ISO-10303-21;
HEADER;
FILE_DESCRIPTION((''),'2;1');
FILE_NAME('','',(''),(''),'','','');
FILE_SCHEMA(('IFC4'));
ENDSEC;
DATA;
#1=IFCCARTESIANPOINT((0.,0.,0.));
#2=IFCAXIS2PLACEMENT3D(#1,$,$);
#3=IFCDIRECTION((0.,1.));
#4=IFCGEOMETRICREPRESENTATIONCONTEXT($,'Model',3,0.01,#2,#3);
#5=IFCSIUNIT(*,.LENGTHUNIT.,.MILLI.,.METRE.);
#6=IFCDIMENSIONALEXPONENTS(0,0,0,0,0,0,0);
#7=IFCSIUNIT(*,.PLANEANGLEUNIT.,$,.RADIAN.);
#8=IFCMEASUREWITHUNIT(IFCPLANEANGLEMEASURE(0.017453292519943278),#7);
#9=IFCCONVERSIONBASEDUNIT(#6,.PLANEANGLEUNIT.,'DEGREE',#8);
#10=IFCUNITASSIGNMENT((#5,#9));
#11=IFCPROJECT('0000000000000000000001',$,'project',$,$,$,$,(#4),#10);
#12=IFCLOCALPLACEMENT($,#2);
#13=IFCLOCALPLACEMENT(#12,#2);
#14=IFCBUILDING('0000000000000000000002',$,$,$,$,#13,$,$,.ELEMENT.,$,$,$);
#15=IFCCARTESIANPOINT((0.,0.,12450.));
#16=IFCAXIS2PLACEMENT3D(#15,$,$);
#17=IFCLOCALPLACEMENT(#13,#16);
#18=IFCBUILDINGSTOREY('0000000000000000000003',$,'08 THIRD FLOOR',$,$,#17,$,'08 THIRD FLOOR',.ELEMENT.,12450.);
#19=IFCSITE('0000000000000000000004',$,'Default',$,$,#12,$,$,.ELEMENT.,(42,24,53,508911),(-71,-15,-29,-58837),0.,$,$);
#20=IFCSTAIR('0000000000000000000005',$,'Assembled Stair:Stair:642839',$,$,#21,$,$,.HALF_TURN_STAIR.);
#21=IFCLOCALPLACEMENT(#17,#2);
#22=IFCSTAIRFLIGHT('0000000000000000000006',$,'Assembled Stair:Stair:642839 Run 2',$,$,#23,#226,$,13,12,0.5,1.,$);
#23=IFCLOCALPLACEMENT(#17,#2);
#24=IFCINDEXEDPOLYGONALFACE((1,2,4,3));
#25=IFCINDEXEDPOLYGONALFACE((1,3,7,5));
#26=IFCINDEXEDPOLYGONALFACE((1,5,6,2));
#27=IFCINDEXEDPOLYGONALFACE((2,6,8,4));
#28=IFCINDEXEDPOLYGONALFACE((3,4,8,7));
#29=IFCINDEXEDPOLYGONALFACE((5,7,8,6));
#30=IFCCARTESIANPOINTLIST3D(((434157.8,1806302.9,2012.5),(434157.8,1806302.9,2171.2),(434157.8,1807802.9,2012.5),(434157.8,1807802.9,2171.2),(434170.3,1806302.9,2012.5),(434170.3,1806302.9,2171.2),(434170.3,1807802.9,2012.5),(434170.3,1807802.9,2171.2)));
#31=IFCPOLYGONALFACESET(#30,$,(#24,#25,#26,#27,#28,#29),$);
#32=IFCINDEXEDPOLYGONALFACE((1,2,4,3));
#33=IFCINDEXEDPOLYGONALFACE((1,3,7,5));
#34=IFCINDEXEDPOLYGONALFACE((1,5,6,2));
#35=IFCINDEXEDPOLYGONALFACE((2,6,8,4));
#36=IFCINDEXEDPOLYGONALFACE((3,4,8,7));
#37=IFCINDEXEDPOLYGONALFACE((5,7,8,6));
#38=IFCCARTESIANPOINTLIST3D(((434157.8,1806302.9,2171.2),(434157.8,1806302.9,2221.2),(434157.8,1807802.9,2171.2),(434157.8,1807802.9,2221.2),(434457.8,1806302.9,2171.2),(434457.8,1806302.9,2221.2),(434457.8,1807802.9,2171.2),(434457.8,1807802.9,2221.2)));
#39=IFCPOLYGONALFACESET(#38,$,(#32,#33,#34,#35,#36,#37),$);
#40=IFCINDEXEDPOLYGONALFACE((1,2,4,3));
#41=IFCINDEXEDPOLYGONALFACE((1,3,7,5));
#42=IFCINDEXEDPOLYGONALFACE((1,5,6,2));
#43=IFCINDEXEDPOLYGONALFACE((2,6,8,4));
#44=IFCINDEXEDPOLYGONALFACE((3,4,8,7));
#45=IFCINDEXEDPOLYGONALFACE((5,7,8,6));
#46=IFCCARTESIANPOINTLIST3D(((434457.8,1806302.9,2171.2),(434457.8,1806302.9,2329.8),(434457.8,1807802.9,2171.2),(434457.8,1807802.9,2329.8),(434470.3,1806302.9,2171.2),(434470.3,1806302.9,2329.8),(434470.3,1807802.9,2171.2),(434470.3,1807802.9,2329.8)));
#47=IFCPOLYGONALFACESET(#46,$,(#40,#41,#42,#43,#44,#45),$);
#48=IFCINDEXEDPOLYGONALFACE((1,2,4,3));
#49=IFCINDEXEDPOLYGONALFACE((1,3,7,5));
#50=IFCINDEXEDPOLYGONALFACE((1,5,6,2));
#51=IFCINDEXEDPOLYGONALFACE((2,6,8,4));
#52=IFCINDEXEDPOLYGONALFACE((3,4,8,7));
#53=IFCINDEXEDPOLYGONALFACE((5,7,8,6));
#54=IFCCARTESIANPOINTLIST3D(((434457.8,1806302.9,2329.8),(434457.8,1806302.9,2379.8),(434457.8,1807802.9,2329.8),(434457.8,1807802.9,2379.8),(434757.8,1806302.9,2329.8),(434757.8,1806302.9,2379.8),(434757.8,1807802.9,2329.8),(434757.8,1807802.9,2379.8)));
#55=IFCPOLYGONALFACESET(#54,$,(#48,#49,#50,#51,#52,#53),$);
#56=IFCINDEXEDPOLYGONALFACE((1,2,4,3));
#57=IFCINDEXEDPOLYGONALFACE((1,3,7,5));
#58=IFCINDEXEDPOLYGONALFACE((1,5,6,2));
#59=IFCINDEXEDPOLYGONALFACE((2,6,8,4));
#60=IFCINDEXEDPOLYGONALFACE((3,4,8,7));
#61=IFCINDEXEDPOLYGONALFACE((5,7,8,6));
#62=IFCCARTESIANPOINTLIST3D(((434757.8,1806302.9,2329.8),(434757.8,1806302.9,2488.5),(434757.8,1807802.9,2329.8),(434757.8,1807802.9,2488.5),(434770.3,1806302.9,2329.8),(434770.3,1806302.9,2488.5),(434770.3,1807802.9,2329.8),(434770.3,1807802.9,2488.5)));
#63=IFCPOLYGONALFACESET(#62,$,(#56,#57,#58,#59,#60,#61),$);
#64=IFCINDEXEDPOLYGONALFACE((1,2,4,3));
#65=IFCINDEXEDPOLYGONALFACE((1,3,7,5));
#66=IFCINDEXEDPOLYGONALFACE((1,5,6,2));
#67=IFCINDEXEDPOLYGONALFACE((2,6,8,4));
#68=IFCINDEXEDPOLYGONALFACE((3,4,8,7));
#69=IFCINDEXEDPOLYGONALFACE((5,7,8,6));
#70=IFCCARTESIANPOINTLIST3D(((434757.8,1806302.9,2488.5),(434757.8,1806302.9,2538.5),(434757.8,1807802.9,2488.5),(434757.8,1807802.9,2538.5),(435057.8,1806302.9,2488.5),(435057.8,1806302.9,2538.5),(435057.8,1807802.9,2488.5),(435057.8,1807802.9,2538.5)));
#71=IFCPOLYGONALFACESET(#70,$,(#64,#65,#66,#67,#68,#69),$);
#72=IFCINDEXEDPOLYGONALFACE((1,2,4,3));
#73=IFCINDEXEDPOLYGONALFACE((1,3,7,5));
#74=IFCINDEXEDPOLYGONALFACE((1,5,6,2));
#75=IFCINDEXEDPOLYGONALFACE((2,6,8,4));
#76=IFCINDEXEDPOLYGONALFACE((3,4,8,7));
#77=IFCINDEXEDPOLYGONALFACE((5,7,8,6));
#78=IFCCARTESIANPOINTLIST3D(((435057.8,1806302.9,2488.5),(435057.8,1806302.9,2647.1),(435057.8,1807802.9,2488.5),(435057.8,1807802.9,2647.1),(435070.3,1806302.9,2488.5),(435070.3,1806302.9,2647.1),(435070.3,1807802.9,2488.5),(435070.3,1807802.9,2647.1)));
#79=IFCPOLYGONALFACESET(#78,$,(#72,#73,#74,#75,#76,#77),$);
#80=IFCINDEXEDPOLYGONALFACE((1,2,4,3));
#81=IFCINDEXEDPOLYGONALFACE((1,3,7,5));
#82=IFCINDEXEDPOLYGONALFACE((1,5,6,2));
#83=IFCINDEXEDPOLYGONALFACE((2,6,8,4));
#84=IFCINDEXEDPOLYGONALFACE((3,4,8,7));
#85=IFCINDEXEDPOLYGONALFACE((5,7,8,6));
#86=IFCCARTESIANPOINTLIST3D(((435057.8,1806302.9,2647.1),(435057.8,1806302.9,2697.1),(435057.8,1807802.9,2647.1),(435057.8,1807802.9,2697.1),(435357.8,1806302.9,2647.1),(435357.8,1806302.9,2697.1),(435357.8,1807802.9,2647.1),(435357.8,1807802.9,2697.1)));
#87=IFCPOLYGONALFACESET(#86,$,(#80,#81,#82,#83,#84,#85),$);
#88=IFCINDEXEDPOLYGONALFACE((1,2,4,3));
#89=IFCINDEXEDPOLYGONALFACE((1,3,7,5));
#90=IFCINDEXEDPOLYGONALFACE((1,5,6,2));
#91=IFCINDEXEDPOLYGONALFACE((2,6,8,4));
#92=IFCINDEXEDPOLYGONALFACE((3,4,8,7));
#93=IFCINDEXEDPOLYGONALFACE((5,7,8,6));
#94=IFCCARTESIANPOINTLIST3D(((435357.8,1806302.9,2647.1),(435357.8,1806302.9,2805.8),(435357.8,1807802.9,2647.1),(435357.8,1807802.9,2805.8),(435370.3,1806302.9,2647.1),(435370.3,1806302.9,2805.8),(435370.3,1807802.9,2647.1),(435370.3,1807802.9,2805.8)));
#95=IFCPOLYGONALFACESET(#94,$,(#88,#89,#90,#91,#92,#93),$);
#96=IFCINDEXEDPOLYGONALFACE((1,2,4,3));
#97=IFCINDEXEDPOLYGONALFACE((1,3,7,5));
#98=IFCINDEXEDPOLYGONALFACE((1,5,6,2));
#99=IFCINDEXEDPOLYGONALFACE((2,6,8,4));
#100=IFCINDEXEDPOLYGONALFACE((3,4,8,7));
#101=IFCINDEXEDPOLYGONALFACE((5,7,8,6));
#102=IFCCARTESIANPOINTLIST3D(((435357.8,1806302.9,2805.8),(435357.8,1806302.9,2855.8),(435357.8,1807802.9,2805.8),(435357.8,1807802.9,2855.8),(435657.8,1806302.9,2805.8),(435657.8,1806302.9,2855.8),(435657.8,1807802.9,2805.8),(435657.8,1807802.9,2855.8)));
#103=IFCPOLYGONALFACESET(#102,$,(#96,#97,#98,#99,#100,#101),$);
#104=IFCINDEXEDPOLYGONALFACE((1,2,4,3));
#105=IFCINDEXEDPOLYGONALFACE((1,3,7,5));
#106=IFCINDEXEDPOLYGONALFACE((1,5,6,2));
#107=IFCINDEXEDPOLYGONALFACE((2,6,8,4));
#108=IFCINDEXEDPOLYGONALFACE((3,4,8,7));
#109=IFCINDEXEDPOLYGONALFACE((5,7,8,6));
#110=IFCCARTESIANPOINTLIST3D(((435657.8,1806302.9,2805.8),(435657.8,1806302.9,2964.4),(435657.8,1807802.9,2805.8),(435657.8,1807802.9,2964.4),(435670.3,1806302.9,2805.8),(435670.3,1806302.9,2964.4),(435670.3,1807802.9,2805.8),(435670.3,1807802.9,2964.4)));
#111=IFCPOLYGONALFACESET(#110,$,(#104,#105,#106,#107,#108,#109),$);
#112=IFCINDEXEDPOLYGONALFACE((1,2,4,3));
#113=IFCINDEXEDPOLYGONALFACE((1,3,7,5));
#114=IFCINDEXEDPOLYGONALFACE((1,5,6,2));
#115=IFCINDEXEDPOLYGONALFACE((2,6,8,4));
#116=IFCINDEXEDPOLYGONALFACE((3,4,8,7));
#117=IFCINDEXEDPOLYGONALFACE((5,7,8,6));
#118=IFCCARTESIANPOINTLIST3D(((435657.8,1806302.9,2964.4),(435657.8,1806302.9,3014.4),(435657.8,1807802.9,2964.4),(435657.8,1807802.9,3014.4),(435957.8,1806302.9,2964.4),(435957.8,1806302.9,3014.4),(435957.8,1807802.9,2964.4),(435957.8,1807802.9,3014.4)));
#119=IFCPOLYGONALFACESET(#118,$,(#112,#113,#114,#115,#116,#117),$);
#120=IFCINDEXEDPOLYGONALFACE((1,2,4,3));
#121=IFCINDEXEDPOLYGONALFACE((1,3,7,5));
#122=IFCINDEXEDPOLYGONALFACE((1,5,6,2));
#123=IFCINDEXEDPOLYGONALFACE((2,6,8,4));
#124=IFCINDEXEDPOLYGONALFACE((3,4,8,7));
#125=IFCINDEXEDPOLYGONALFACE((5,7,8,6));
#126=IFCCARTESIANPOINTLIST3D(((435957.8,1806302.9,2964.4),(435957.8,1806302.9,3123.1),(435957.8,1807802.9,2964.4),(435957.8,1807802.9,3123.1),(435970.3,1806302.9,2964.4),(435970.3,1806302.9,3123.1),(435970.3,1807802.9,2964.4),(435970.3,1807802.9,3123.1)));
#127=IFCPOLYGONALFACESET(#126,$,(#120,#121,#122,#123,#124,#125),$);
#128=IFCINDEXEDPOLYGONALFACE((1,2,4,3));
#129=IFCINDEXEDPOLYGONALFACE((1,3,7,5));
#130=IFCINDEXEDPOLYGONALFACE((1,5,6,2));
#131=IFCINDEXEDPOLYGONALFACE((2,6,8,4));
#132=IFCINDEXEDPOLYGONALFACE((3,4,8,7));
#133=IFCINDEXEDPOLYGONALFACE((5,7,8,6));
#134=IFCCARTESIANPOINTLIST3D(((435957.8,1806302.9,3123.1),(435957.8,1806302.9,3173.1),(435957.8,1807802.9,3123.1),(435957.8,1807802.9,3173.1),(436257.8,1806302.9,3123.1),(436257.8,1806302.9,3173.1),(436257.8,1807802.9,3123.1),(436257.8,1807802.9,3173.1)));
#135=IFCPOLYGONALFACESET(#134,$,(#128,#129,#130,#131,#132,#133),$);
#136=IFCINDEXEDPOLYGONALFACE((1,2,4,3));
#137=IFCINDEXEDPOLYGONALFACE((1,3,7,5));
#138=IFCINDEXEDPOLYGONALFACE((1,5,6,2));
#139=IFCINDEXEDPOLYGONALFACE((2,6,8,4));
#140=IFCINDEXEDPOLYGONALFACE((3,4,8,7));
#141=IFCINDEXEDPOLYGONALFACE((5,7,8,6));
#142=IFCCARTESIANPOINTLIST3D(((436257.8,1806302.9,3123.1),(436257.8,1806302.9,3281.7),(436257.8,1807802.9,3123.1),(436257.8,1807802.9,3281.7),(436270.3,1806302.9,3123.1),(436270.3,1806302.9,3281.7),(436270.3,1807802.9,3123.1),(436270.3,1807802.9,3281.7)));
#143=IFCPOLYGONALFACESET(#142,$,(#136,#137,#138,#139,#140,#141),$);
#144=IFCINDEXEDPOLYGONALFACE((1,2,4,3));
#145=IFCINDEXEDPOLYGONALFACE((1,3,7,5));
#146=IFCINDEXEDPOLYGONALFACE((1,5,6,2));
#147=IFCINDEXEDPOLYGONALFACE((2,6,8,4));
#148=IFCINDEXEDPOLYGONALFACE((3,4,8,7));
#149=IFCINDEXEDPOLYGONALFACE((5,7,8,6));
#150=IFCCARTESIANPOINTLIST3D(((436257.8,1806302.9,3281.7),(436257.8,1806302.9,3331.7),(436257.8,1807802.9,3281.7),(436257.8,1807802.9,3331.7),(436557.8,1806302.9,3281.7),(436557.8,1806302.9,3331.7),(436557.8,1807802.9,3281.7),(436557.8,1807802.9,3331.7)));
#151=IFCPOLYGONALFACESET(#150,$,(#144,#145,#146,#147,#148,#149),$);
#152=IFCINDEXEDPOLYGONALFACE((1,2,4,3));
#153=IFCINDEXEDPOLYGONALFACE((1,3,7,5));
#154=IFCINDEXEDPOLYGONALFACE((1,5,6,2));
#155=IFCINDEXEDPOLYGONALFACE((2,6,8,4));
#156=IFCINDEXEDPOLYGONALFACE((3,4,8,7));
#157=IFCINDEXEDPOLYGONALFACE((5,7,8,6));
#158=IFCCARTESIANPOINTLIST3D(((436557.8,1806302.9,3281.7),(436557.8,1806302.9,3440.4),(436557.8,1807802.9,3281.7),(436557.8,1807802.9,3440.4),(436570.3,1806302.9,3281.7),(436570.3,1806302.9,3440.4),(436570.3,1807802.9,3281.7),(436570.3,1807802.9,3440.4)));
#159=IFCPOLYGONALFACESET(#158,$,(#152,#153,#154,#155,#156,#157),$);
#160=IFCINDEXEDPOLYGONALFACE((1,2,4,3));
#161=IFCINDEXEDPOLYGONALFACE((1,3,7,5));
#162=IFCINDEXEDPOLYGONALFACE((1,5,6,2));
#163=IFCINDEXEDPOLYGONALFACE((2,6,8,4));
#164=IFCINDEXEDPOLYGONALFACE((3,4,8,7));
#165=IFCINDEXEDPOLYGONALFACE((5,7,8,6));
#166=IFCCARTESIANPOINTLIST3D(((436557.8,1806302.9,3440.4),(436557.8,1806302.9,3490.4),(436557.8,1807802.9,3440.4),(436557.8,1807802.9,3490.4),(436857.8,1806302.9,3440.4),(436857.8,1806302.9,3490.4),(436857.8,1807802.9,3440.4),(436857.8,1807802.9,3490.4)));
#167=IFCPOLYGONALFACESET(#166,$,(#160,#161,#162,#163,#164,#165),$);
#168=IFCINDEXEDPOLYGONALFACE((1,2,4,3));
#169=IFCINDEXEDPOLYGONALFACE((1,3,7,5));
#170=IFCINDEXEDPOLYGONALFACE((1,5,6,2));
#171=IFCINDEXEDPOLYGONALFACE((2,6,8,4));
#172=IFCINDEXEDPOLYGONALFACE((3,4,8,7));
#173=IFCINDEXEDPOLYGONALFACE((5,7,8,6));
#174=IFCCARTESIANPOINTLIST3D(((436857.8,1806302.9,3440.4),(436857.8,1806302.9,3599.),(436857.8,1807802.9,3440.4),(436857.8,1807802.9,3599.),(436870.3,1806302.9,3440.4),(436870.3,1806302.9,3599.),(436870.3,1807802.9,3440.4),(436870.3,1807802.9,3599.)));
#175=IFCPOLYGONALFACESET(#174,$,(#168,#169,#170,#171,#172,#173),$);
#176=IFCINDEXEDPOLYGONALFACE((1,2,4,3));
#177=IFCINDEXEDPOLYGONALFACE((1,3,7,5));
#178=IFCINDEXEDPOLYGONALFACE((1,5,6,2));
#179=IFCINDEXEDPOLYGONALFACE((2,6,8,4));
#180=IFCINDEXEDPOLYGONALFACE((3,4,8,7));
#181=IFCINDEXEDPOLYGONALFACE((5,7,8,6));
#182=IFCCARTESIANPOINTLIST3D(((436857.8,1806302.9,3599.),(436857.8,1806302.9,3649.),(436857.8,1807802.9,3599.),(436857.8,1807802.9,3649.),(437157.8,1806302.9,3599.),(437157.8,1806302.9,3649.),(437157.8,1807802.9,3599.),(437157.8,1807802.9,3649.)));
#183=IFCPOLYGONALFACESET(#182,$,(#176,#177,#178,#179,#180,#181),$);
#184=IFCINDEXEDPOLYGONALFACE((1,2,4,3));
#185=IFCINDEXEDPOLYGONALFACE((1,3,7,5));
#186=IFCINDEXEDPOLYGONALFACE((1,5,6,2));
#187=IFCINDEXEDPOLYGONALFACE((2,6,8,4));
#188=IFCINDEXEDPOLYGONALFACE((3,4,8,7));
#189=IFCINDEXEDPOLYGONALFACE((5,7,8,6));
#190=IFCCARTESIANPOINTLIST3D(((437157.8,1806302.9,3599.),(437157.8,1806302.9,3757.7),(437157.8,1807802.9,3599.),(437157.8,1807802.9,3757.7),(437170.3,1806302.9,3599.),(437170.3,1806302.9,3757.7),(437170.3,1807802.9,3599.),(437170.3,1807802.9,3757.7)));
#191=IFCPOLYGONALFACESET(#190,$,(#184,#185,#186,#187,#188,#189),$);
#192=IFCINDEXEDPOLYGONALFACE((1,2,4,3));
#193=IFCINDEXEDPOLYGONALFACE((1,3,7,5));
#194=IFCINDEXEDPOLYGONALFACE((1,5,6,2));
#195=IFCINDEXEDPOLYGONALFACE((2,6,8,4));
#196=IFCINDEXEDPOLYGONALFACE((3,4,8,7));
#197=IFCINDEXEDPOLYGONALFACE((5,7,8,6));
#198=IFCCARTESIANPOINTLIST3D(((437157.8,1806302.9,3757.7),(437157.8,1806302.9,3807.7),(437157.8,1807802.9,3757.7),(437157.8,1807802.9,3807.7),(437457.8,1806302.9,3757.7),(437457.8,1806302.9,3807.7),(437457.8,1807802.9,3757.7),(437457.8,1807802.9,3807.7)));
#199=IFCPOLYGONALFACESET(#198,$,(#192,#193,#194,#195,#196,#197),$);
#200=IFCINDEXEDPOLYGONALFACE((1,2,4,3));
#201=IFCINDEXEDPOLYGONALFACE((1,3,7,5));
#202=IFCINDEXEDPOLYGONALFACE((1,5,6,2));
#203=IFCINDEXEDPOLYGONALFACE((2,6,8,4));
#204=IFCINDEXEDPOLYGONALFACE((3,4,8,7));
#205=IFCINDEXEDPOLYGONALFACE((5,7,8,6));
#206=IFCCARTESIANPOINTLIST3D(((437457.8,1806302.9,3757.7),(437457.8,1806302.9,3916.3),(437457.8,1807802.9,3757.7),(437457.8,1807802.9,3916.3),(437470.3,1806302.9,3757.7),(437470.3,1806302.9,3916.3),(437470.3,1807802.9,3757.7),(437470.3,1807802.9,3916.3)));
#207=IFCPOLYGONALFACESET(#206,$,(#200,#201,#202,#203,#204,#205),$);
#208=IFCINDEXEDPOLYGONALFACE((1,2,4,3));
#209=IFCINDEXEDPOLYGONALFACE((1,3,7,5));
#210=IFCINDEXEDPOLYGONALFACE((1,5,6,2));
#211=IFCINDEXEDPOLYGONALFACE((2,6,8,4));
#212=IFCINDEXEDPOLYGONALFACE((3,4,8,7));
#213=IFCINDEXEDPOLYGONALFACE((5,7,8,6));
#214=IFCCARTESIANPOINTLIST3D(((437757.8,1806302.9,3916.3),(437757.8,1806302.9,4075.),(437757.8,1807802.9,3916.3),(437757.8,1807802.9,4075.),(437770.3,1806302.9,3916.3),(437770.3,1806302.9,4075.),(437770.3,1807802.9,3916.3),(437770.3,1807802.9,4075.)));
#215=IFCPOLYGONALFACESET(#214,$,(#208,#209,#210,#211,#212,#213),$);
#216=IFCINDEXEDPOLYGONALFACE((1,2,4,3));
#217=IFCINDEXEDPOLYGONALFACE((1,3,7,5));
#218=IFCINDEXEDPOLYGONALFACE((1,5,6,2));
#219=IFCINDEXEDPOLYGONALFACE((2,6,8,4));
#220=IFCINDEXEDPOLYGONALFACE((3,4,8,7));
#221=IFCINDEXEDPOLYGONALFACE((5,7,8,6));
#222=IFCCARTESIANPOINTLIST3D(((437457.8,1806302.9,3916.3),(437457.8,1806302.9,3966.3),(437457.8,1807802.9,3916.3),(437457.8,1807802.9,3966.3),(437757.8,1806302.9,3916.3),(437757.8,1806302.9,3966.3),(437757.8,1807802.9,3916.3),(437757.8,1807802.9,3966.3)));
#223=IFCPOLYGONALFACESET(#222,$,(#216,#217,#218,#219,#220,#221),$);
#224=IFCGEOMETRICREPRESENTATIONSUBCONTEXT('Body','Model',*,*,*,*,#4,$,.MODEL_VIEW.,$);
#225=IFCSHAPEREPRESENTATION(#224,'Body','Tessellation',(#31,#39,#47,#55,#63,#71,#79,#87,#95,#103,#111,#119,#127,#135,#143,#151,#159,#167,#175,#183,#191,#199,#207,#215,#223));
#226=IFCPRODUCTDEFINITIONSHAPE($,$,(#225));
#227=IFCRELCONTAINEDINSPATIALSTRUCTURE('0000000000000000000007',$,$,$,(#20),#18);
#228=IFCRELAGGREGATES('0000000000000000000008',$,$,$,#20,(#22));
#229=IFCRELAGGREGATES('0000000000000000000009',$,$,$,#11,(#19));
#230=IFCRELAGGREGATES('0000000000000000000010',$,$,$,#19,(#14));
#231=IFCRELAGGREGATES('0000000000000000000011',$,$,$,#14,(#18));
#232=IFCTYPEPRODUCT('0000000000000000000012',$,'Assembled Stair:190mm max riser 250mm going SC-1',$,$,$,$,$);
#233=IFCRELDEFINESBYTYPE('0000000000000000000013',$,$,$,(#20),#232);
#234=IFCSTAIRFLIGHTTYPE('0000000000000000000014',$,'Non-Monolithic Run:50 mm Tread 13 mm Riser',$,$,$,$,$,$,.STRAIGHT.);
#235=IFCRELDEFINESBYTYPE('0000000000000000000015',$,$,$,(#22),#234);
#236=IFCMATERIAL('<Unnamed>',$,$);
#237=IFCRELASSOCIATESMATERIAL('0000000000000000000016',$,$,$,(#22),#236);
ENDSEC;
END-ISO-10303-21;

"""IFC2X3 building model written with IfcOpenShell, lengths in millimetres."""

from ifc_helpers import new_model, entity, si_unit, converted_unit, direction, frame, origin, origin_2d_with_axis, place, context, subcontext, project, spatial, rectangle, extrude, material, type_object, element, aggregate, save


model = new_model("IFC2X3")

# Units and contexts
model_context = context("Model", 3, precision=0.01, world=origin(), true_north=direction((0.0, 1.0)))
body_context = subcontext(model_context, "Body", "Model", "MODEL_VIEW")
ifc_project = project(units=[si_unit("LENGTHUNIT", "METRE", prefix="MILLI"), converted_unit("PLANEANGLEUNIT", "DEGREE", entity("IfcPlaneAngleMeasure", 0.017453292519943278), si_unit("PLANEANGLEUNIT", "RADIAN"), dimensions=[0, 0, 0, 0, 0, 0, 0])], contexts=[model_context])

# Site, building, storey
site_placement = place(None, origin())
site = spatial("IfcSite", under=ifc_project, at=site_placement, Name="Default", CompositionType="ELEMENT", RefLatitude=(42, 24, 53, 508911), RefLongitude=(-71, -15, -29, -58837), RefElevation=0.0)
building_placement = place(site_placement, origin())
building = spatial("IfcBuilding", under=site, at=building_placement, CompositionType="ELEMENT")
storey_placement = place(building_placement, frame((0.0, 0.0, 12450.0)))
storey = spatial("IfcBuildingStorey", under=building, at=storey_placement, Name="08 THIRD FLOOR", LongName="08 THIRD FLOOR", CompositionType="ELEMENT", Elevation=12450.0)

# Stair
type_product_1 = type_object("IfcTypeProduct", Name="Assembled Stair:190mm max riser 250mm going SC-1")
stair_1_placement = place(storey_placement, origin())
stair_1 = element("IfcStair", 1, at=stair_1_placement, inside=storey, type_object=type_product_1, Name="Assembled Stair:Stair:642839", ShapeType="HALF_TURN_STAIR")
ifc_material_1 = material(Name="<Unnamed>")

# Stair flight
stair_flight_type = type_object("IfcStairFlightType", Name="Non-Monolithic Run:50 mm Tread 13 mm Riser", PredefinedType="STRAIGHT")
stair_flight_1_placement = place(stair_1_placement, origin())
stair_flight_1 = element("IfcStairFlight", 2, at=stair_flight_1_placement, type_object=stair_flight_type, material=ifc_material_1, Name="Assembled Stair:Stair:642839 Run 2", NumberOfRiser=13, NumberOfTreads=12, RiserHeight=0.5, TreadLength=1.0, context=body_context, shape_type="SweptSolid", body=[
    extrude(rectangle(XDim=1500.0, YDim=12.5, at=origin_2d_with_axis()), frame((434164.0, 1807052.9, 2012.5), z_axis=(0.0, 0.0, 1.0), x_axis=(0.0, 1.0, 0.0)), (0.0, 0.0, 1.0), 158.7),
    extrude(rectangle(XDim=300.0, YDim=1500.0, at=origin_2d_with_axis()), frame((434307.8, 1807052.9, 2171.2), z_axis=(0.0, 0.0, 1.0), x_axis=(-1.0, 0.0, 0.0)), (0.0, 0.0, 1.0), 50.0),
    extrude(rectangle(XDim=1500.0, YDim=12.5, at=origin_2d_with_axis()), frame((434464.0, 1807052.9, 2171.2), z_axis=(0.0, 0.0, 1.0), x_axis=(0.0, 1.0, 0.0)), (0.0, 0.0, 1.0), 158.7),
    extrude(rectangle(XDim=300.0, YDim=1500.0, at=origin_2d_with_axis()), frame((434607.8, 1807052.9, 2329.8), z_axis=(0.0, 0.0, 1.0), x_axis=(-1.0, 0.0, 0.0)), (0.0, 0.0, 1.0), 50.0),
    extrude(rectangle(XDim=1500.0, YDim=12.5, at=origin_2d_with_axis()), frame((434764.0, 1807052.9, 2329.8), z_axis=(0.0, 0.0, 1.0), x_axis=(0.0, 1.0, 0.0)), (0.0, 0.0, 1.0), 158.7),
    extrude(rectangle(XDim=300.0, YDim=1500.0, at=origin_2d_with_axis()), frame((434907.8, 1807052.9, 2488.5), z_axis=(0.0, 0.0, 1.0), x_axis=(-1.0, 0.0, 0.0)), (0.0, 0.0, 1.0), 50.0),
    extrude(rectangle(XDim=1500.0, YDim=12.5, at=origin_2d_with_axis()), frame((435064.0, 1807052.9, 2488.5), z_axis=(0.0, 0.0, 1.0), x_axis=(0.0, 1.0, 0.0)), (0.0, 0.0, 1.0), 158.7),
    extrude(rectangle(XDim=300.0, YDim=1500.0, at=origin_2d_with_axis()), frame((435207.8, 1807052.9, 2647.1), z_axis=(0.0, 0.0, 1.0), x_axis=(-1.0, 0.0, 0.0)), (0.0, 0.0, 1.0), 50.0),
    extrude(rectangle(XDim=1500.0, YDim=12.5, at=origin_2d_with_axis()), frame((435364.0, 1807052.9, 2647.1), z_axis=(0.0, 0.0, 1.0), x_axis=(0.0, 1.0, 0.0)), (0.0, 0.0, 1.0), 158.7),
    extrude(rectangle(XDim=300.0, YDim=1500.0, at=origin_2d_with_axis()), frame((435507.8, 1807052.9, 2805.8), z_axis=(0.0, 0.0, 1.0), x_axis=(-1.0, 0.0, 0.0)), (0.0, 0.0, 1.0), 50.0),
    extrude(rectangle(XDim=1500.0, YDim=12.5, at=origin_2d_with_axis()), frame((435664.0, 1807052.9, 2805.8), z_axis=(0.0, 0.0, 1.0), x_axis=(0.0, 1.0, 0.0)), (0.0, 0.0, 1.0), 158.7),
    extrude(rectangle(XDim=300.0, YDim=1500.0, at=origin_2d_with_axis()), frame((435807.8, 1807052.9, 2964.4), z_axis=(0.0, 0.0, 1.0), x_axis=(-1.0, 0.0, 0.0)), (0.0, 0.0, 1.0), 50.0),
    extrude(rectangle(XDim=1500.0, YDim=12.5, at=origin_2d_with_axis()), frame((435964.0, 1807052.9, 2964.4), z_axis=(0.0, 0.0, 1.0), x_axis=(0.0, 1.0, 0.0)), (0.0, 0.0, 1.0), 158.7),
    extrude(rectangle(XDim=300.0, YDim=1500.0, at=origin_2d_with_axis()), frame((436107.8, 1807052.9, 3123.1), z_axis=(0.0, 0.0, 1.0), x_axis=(-1.0, 0.0, 0.0)), (0.0, 0.0, 1.0), 50.0),
    extrude(rectangle(XDim=1500.0, YDim=12.5, at=origin_2d_with_axis()), frame((436264.0, 1807052.9, 3123.1), z_axis=(0.0, 0.0, 1.0), x_axis=(0.0, 1.0, 0.0)), (0.0, 0.0, 1.0), 158.7),
    extrude(rectangle(XDim=300.0, YDim=1500.0, at=origin_2d_with_axis()), frame((436407.8, 1807052.9, 3281.7), z_axis=(0.0, 0.0, 1.0), x_axis=(-1.0, 0.0, 0.0)), (0.0, 0.0, 1.0), 50.0),
    extrude(rectangle(XDim=1500.0, YDim=12.5, at=origin_2d_with_axis()), frame((436564.0, 1807052.9, 3281.7), z_axis=(0.0, 0.0, 1.0), x_axis=(0.0, 1.0, 0.0)), (0.0, 0.0, 1.0), 158.7),
    extrude(rectangle(XDim=300.0, YDim=1500.0, at=origin_2d_with_axis()), frame((436707.8, 1807052.9, 3440.4), z_axis=(0.0, 0.0, 1.0), x_axis=(-1.0, 0.0, 0.0)), (0.0, 0.0, 1.0), 50.0),
    extrude(rectangle(XDim=1500.0, YDim=12.5, at=origin_2d_with_axis()), frame((436864.0, 1807052.9, 3440.4), z_axis=(0.0, 0.0, 1.0), x_axis=(0.0, 1.0, 0.0)), (0.0, 0.0, 1.0), 158.7),
    extrude(rectangle(XDim=300.0, YDim=1500.0, at=origin_2d_with_axis()), frame((437007.8, 1807052.9, 3599.0), z_axis=(0.0, 0.0, 1.0), x_axis=(-1.0, 0.0, 0.0)), (0.0, 0.0, 1.0), 50.0),
    extrude(rectangle(XDim=1500.0, YDim=12.5, at=origin_2d_with_axis()), frame((437164.0, 1807052.9, 3599.0), z_axis=(0.0, 0.0, 1.0), x_axis=(0.0, 1.0, 0.0)), (0.0, 0.0, 1.0), 158.7),
    extrude(rectangle(XDim=300.0, YDim=1500.0, at=origin_2d_with_axis()), frame((437307.8, 1807052.9, 3757.7), z_axis=(0.0, 0.0, 1.0), x_axis=(-1.0, 0.0, 0.0)), (0.0, 0.0, 1.0), 50.0),
    extrude(rectangle(XDim=1500.0, YDim=12.5, at=origin_2d_with_axis()), frame((437464.0, 1807052.9, 3757.7), z_axis=(0.0, 0.0, 1.0), x_axis=(0.0, 1.0, 0.0)), (0.0, 0.0, 1.0), 158.7),
    extrude(rectangle(XDim=1500.0, YDim=12.5, at=origin_2d_with_axis()), frame((437764.0, 1807052.9, 3916.3), z_axis=(0.0, 0.0, 1.0), x_axis=(0.0, 1.0, 0.0)), (0.0, 0.0, 1.0), 158.7),
    extrude(rectangle(XDim=300.0, YDim=1500.0, at=origin_2d_with_axis()), frame((437607.8, 1807052.9, 3916.3), z_axis=(0.0, 0.0, 1.0), x_axis=(-1.0, 0.0, 0.0)), (0.0, 0.0, 1.0), 50.0),
])
aggregate(stair_1, [stair_flight_1])

save(model, "model.ifc")
